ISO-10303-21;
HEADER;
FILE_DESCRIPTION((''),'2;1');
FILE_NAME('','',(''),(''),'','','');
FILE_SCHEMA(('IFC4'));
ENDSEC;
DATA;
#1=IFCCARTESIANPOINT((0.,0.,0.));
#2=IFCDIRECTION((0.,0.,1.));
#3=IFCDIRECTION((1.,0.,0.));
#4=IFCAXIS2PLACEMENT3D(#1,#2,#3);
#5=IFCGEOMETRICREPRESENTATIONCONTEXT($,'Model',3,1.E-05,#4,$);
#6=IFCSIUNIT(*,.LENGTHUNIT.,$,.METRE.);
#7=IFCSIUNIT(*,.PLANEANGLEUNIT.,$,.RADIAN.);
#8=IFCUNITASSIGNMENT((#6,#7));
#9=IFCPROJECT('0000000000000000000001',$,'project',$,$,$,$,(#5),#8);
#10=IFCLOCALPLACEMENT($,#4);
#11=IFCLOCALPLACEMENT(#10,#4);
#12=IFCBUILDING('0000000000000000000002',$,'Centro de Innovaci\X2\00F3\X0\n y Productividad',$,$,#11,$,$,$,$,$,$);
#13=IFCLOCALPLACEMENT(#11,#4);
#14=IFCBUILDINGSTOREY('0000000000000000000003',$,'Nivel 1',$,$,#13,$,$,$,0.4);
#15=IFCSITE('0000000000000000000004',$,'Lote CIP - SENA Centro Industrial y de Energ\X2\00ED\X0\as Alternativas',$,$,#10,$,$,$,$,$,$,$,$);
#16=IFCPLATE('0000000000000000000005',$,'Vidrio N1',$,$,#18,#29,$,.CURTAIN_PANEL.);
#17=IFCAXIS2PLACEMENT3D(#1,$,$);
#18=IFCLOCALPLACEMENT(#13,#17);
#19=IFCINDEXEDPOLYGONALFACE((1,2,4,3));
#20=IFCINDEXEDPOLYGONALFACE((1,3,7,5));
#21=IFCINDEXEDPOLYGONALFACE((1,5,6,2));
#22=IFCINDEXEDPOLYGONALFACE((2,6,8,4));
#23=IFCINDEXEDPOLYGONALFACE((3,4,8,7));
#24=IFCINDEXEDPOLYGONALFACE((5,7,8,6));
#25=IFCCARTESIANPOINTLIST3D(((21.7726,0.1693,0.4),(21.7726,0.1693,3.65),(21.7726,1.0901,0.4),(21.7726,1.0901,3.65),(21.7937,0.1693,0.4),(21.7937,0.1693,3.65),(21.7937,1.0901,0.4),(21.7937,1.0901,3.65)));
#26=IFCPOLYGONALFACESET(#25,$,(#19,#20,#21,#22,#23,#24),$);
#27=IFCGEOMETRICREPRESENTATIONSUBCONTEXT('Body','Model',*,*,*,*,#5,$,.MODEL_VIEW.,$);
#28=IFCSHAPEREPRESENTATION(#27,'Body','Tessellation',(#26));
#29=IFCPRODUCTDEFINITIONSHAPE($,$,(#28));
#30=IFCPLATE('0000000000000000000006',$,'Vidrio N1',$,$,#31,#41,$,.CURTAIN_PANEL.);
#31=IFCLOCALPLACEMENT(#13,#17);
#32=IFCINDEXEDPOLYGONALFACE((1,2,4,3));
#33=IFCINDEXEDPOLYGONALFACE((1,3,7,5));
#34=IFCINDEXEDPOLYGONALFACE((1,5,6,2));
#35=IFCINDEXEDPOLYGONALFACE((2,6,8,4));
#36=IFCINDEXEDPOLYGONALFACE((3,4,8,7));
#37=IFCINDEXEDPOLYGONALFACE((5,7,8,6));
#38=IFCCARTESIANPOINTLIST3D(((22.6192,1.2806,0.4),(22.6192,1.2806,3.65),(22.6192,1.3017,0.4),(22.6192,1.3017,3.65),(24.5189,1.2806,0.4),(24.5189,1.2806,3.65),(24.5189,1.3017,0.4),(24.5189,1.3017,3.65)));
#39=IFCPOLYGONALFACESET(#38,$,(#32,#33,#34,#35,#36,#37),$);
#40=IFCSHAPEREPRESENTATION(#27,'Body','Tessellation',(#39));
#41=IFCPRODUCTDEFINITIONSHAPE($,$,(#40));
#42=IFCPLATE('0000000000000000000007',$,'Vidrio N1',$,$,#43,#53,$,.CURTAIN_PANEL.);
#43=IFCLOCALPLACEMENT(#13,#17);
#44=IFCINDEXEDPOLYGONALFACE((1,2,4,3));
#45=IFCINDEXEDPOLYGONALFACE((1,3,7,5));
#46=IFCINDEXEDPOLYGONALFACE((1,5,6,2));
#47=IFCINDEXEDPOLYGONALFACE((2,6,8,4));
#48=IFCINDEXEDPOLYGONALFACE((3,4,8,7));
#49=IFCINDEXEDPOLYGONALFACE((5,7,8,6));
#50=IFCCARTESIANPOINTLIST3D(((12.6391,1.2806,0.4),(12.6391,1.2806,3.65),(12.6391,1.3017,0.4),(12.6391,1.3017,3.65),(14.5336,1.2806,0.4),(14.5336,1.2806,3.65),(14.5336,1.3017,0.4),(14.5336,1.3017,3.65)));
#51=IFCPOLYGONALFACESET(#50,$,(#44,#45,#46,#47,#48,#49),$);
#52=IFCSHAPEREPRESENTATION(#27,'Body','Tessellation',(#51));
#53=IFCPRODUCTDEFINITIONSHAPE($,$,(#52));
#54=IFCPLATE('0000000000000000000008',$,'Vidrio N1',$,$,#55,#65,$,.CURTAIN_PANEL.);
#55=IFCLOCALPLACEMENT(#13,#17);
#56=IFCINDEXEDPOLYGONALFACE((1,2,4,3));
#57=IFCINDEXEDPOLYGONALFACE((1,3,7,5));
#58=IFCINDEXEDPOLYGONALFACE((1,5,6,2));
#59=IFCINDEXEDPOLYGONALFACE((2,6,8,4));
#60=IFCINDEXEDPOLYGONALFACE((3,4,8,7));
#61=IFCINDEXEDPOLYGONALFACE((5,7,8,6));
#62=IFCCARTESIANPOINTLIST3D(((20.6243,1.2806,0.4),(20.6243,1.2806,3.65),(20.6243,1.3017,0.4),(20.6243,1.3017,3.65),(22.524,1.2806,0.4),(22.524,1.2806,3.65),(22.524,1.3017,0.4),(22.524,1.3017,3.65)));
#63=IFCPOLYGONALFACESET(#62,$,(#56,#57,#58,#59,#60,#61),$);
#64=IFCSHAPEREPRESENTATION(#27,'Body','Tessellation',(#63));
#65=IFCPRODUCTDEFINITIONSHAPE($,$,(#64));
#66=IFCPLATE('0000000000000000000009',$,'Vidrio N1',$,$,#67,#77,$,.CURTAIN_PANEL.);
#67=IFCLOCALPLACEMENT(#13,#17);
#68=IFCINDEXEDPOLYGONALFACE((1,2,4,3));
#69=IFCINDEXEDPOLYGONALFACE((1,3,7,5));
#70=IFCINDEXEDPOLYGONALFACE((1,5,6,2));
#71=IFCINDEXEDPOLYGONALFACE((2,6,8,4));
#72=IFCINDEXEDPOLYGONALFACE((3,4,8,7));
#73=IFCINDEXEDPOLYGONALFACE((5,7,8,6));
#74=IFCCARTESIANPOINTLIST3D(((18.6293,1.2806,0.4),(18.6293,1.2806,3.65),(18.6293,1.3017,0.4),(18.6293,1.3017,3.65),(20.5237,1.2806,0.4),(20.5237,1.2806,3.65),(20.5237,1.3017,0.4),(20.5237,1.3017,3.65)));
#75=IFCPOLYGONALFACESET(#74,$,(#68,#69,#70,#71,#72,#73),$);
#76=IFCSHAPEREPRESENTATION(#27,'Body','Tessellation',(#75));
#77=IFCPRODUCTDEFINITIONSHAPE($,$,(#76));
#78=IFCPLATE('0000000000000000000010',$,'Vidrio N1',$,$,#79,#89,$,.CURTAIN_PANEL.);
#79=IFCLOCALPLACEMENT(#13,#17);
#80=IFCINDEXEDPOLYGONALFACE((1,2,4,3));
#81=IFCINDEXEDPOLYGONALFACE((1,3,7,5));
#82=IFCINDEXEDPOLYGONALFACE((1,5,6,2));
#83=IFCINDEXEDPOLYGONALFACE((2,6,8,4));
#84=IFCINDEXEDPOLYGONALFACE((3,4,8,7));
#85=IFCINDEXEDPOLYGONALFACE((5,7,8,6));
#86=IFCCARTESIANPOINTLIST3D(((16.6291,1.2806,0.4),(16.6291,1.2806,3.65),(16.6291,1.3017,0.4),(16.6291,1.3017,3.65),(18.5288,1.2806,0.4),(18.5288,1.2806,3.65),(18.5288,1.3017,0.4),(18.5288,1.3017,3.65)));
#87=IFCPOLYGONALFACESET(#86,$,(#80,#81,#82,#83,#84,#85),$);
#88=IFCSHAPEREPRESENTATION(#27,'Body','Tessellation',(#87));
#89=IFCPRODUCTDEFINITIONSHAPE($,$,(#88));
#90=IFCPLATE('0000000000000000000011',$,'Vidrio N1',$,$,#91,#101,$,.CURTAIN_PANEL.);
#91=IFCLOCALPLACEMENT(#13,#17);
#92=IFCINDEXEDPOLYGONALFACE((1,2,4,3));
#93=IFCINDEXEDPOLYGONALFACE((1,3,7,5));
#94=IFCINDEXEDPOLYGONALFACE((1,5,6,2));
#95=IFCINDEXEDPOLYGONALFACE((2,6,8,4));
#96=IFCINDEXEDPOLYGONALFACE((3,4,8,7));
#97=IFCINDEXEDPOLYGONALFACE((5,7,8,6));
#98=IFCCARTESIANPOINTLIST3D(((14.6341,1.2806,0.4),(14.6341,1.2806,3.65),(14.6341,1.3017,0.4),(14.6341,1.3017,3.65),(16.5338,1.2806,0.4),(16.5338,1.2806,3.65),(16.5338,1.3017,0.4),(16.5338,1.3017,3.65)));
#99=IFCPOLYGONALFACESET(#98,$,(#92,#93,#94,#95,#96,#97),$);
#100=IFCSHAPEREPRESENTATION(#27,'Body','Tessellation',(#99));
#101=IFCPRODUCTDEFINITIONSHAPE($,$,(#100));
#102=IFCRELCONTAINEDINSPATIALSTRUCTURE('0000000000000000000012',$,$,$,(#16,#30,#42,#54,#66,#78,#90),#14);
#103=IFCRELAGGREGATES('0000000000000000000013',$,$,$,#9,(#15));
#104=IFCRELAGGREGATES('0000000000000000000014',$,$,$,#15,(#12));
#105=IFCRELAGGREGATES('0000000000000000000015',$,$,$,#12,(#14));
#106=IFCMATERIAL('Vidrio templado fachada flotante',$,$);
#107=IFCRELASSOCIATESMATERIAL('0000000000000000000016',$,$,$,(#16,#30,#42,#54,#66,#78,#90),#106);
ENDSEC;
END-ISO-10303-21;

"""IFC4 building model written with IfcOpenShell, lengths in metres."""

from ifc_helpers import new_model, si_unit, frame, origin_with_axes, place, context, subcontext, project, spatial, polyline, outline, extrude, material, element, save


model = new_model("IFC4")

# Units and contexts
model_context = context("Model", 3, precision=1e-05, world=origin_with_axes())
body_context = subcontext(model_context, "Body", "Model", "MODEL_VIEW")
ifc_project = project(units=[si_unit("LENGTHUNIT", "METRE"), si_unit("PLANEANGLEUNIT", "RADIAN")], contexts=[model_context])

# Site, building, storey
site_placement = place(None, origin_with_axes())
site = spatial("IfcSite", under=ifc_project, at=site_placement, Name="Lote CIP - SENA Centro Industrial y de Energías Alternativas")
building_placement = place(site_placement, origin_with_axes())
building = spatial("IfcBuilding", under=site, at=building_placement, Name="Centro de Innovación y Productividad")
storey_placement = place(building_placement, origin_with_axes())
storey = spatial("IfcBuildingStorey", under=building, at=storey_placement, Name="Nivel 1", Elevation=0.4)

# Plates
ifc_material = material(Name="Vidrio templado fachada flotante")
plate_1_placement = place(storey_placement, origin_with_axes())
element("IfcPlate", 1, at=plate_1_placement, inside=storey, material=ifc_material, Name="Vidrio N1", PredefinedType="CURTAIN_PANEL", context=body_context, shape_type="SweptSolid", body=[
    extrude(outline(polyline([(21.7726, 1.0901), (21.7937, 1.0901), (21.7937, 0.1693), (21.7726, 0.1693), (21.7726, 1.0901)])), frame((0.0, 0.0, 0.4)), (0.0, 0.0, 1.0), 3.25),
])
plate_2_placement = place(storey_placement, origin_with_axes())
element("IfcPlate", 2, at=plate_2_placement, inside=storey, material=ifc_material, Name="Vidrio N1", PredefinedType="CURTAIN_PANEL", context=body_context, shape_type="SweptSolid", body=[
    extrude(outline(polyline([(24.5189, 1.2806), (22.6192, 1.2806), (22.6192, 1.3017), (24.5189, 1.3017), (24.5189, 1.2806)])), frame((0.0, 0.0, 0.4)), (0.0, 0.0, 1.0), 3.25),
])
plate_3_placement = place(storey_placement, origin_with_axes())
element("IfcPlate", 3, at=plate_3_placement, inside=storey, material=ifc_material, Name="Vidrio N1", PredefinedType="CURTAIN_PANEL", context=body_context, shape_type="SweptSolid", body=[
    extrude(outline(polyline([(12.6391, 1.2806), (12.6391, 1.3017), (14.5336, 1.3017), (14.5336, 1.2806), (12.6391, 1.2806)])), frame((0.0, 0.0, 0.4)), (0.0, 0.0, 1.0), 3.25),
])
plate_4_placement = place(storey_placement, origin_with_axes())
element("IfcPlate", 4, at=plate_4_placement, inside=storey, material=ifc_material, Name="Vidrio N1", PredefinedType="CURTAIN_PANEL", context=body_context, shape_type="SweptSolid", body=[
    extrude(outline(polyline([(20.6243, 1.3017), (22.524, 1.3017), (22.524, 1.2806), (20.6243, 1.2806), (20.6243, 1.3017)])), frame((0.0, 0.0, 0.4)), (0.0, 0.0, 1.0), 3.25),
])
plate_5_placement = place(storey_placement, origin_with_axes())
element("IfcPlate", 5, at=plate_5_placement, inside=storey, material=ifc_material, Name="Vidrio N1", PredefinedType="CURTAIN_PANEL", context=body_context, shape_type="SweptSolid", body=[
    extrude(outline(polyline([(20.5237, 1.3017), (20.5237, 1.2806), (18.6293, 1.2806), (18.6293, 1.3017), (20.5237, 1.3017)])), frame((0.0, 0.0, 0.4)), (0.0, 0.0, 1.0), 3.25),
])
plate_6_placement = place(storey_placement, origin_with_axes())
element("IfcPlate", 6, at=plate_6_placement, inside=storey, material=ifc_material, Name="Vidrio N1", PredefinedType="CURTAIN_PANEL", context=body_context, shape_type="SweptSolid", body=[
    extrude(outline(polyline([(16.6291, 1.3017), (18.5288, 1.3017), (18.5288, 1.2806), (16.6291, 1.2806), (16.6291, 1.3017)])), frame((0.0, 0.0, 0.4)), (0.0, 0.0, 1.0), 3.25),
])
plate_7_placement = place(storey_placement, origin_with_axes())
element("IfcPlate", 7, at=plate_7_placement, inside=storey, material=ifc_material, Name="Vidrio N1", PredefinedType="CURTAIN_PANEL", context=body_context, shape_type="SweptSolid", body=[
    extrude(outline(polyline([(14.6341, 1.2806), (14.6341, 1.3017), (16.5338, 1.3017), (16.5338, 1.2806), (14.6341, 1.2806)])), frame((0.0, 0.0, 0.4)), (0.0, 0.0, 1.0), 3.25),
])

save(model, "model.ifc")
